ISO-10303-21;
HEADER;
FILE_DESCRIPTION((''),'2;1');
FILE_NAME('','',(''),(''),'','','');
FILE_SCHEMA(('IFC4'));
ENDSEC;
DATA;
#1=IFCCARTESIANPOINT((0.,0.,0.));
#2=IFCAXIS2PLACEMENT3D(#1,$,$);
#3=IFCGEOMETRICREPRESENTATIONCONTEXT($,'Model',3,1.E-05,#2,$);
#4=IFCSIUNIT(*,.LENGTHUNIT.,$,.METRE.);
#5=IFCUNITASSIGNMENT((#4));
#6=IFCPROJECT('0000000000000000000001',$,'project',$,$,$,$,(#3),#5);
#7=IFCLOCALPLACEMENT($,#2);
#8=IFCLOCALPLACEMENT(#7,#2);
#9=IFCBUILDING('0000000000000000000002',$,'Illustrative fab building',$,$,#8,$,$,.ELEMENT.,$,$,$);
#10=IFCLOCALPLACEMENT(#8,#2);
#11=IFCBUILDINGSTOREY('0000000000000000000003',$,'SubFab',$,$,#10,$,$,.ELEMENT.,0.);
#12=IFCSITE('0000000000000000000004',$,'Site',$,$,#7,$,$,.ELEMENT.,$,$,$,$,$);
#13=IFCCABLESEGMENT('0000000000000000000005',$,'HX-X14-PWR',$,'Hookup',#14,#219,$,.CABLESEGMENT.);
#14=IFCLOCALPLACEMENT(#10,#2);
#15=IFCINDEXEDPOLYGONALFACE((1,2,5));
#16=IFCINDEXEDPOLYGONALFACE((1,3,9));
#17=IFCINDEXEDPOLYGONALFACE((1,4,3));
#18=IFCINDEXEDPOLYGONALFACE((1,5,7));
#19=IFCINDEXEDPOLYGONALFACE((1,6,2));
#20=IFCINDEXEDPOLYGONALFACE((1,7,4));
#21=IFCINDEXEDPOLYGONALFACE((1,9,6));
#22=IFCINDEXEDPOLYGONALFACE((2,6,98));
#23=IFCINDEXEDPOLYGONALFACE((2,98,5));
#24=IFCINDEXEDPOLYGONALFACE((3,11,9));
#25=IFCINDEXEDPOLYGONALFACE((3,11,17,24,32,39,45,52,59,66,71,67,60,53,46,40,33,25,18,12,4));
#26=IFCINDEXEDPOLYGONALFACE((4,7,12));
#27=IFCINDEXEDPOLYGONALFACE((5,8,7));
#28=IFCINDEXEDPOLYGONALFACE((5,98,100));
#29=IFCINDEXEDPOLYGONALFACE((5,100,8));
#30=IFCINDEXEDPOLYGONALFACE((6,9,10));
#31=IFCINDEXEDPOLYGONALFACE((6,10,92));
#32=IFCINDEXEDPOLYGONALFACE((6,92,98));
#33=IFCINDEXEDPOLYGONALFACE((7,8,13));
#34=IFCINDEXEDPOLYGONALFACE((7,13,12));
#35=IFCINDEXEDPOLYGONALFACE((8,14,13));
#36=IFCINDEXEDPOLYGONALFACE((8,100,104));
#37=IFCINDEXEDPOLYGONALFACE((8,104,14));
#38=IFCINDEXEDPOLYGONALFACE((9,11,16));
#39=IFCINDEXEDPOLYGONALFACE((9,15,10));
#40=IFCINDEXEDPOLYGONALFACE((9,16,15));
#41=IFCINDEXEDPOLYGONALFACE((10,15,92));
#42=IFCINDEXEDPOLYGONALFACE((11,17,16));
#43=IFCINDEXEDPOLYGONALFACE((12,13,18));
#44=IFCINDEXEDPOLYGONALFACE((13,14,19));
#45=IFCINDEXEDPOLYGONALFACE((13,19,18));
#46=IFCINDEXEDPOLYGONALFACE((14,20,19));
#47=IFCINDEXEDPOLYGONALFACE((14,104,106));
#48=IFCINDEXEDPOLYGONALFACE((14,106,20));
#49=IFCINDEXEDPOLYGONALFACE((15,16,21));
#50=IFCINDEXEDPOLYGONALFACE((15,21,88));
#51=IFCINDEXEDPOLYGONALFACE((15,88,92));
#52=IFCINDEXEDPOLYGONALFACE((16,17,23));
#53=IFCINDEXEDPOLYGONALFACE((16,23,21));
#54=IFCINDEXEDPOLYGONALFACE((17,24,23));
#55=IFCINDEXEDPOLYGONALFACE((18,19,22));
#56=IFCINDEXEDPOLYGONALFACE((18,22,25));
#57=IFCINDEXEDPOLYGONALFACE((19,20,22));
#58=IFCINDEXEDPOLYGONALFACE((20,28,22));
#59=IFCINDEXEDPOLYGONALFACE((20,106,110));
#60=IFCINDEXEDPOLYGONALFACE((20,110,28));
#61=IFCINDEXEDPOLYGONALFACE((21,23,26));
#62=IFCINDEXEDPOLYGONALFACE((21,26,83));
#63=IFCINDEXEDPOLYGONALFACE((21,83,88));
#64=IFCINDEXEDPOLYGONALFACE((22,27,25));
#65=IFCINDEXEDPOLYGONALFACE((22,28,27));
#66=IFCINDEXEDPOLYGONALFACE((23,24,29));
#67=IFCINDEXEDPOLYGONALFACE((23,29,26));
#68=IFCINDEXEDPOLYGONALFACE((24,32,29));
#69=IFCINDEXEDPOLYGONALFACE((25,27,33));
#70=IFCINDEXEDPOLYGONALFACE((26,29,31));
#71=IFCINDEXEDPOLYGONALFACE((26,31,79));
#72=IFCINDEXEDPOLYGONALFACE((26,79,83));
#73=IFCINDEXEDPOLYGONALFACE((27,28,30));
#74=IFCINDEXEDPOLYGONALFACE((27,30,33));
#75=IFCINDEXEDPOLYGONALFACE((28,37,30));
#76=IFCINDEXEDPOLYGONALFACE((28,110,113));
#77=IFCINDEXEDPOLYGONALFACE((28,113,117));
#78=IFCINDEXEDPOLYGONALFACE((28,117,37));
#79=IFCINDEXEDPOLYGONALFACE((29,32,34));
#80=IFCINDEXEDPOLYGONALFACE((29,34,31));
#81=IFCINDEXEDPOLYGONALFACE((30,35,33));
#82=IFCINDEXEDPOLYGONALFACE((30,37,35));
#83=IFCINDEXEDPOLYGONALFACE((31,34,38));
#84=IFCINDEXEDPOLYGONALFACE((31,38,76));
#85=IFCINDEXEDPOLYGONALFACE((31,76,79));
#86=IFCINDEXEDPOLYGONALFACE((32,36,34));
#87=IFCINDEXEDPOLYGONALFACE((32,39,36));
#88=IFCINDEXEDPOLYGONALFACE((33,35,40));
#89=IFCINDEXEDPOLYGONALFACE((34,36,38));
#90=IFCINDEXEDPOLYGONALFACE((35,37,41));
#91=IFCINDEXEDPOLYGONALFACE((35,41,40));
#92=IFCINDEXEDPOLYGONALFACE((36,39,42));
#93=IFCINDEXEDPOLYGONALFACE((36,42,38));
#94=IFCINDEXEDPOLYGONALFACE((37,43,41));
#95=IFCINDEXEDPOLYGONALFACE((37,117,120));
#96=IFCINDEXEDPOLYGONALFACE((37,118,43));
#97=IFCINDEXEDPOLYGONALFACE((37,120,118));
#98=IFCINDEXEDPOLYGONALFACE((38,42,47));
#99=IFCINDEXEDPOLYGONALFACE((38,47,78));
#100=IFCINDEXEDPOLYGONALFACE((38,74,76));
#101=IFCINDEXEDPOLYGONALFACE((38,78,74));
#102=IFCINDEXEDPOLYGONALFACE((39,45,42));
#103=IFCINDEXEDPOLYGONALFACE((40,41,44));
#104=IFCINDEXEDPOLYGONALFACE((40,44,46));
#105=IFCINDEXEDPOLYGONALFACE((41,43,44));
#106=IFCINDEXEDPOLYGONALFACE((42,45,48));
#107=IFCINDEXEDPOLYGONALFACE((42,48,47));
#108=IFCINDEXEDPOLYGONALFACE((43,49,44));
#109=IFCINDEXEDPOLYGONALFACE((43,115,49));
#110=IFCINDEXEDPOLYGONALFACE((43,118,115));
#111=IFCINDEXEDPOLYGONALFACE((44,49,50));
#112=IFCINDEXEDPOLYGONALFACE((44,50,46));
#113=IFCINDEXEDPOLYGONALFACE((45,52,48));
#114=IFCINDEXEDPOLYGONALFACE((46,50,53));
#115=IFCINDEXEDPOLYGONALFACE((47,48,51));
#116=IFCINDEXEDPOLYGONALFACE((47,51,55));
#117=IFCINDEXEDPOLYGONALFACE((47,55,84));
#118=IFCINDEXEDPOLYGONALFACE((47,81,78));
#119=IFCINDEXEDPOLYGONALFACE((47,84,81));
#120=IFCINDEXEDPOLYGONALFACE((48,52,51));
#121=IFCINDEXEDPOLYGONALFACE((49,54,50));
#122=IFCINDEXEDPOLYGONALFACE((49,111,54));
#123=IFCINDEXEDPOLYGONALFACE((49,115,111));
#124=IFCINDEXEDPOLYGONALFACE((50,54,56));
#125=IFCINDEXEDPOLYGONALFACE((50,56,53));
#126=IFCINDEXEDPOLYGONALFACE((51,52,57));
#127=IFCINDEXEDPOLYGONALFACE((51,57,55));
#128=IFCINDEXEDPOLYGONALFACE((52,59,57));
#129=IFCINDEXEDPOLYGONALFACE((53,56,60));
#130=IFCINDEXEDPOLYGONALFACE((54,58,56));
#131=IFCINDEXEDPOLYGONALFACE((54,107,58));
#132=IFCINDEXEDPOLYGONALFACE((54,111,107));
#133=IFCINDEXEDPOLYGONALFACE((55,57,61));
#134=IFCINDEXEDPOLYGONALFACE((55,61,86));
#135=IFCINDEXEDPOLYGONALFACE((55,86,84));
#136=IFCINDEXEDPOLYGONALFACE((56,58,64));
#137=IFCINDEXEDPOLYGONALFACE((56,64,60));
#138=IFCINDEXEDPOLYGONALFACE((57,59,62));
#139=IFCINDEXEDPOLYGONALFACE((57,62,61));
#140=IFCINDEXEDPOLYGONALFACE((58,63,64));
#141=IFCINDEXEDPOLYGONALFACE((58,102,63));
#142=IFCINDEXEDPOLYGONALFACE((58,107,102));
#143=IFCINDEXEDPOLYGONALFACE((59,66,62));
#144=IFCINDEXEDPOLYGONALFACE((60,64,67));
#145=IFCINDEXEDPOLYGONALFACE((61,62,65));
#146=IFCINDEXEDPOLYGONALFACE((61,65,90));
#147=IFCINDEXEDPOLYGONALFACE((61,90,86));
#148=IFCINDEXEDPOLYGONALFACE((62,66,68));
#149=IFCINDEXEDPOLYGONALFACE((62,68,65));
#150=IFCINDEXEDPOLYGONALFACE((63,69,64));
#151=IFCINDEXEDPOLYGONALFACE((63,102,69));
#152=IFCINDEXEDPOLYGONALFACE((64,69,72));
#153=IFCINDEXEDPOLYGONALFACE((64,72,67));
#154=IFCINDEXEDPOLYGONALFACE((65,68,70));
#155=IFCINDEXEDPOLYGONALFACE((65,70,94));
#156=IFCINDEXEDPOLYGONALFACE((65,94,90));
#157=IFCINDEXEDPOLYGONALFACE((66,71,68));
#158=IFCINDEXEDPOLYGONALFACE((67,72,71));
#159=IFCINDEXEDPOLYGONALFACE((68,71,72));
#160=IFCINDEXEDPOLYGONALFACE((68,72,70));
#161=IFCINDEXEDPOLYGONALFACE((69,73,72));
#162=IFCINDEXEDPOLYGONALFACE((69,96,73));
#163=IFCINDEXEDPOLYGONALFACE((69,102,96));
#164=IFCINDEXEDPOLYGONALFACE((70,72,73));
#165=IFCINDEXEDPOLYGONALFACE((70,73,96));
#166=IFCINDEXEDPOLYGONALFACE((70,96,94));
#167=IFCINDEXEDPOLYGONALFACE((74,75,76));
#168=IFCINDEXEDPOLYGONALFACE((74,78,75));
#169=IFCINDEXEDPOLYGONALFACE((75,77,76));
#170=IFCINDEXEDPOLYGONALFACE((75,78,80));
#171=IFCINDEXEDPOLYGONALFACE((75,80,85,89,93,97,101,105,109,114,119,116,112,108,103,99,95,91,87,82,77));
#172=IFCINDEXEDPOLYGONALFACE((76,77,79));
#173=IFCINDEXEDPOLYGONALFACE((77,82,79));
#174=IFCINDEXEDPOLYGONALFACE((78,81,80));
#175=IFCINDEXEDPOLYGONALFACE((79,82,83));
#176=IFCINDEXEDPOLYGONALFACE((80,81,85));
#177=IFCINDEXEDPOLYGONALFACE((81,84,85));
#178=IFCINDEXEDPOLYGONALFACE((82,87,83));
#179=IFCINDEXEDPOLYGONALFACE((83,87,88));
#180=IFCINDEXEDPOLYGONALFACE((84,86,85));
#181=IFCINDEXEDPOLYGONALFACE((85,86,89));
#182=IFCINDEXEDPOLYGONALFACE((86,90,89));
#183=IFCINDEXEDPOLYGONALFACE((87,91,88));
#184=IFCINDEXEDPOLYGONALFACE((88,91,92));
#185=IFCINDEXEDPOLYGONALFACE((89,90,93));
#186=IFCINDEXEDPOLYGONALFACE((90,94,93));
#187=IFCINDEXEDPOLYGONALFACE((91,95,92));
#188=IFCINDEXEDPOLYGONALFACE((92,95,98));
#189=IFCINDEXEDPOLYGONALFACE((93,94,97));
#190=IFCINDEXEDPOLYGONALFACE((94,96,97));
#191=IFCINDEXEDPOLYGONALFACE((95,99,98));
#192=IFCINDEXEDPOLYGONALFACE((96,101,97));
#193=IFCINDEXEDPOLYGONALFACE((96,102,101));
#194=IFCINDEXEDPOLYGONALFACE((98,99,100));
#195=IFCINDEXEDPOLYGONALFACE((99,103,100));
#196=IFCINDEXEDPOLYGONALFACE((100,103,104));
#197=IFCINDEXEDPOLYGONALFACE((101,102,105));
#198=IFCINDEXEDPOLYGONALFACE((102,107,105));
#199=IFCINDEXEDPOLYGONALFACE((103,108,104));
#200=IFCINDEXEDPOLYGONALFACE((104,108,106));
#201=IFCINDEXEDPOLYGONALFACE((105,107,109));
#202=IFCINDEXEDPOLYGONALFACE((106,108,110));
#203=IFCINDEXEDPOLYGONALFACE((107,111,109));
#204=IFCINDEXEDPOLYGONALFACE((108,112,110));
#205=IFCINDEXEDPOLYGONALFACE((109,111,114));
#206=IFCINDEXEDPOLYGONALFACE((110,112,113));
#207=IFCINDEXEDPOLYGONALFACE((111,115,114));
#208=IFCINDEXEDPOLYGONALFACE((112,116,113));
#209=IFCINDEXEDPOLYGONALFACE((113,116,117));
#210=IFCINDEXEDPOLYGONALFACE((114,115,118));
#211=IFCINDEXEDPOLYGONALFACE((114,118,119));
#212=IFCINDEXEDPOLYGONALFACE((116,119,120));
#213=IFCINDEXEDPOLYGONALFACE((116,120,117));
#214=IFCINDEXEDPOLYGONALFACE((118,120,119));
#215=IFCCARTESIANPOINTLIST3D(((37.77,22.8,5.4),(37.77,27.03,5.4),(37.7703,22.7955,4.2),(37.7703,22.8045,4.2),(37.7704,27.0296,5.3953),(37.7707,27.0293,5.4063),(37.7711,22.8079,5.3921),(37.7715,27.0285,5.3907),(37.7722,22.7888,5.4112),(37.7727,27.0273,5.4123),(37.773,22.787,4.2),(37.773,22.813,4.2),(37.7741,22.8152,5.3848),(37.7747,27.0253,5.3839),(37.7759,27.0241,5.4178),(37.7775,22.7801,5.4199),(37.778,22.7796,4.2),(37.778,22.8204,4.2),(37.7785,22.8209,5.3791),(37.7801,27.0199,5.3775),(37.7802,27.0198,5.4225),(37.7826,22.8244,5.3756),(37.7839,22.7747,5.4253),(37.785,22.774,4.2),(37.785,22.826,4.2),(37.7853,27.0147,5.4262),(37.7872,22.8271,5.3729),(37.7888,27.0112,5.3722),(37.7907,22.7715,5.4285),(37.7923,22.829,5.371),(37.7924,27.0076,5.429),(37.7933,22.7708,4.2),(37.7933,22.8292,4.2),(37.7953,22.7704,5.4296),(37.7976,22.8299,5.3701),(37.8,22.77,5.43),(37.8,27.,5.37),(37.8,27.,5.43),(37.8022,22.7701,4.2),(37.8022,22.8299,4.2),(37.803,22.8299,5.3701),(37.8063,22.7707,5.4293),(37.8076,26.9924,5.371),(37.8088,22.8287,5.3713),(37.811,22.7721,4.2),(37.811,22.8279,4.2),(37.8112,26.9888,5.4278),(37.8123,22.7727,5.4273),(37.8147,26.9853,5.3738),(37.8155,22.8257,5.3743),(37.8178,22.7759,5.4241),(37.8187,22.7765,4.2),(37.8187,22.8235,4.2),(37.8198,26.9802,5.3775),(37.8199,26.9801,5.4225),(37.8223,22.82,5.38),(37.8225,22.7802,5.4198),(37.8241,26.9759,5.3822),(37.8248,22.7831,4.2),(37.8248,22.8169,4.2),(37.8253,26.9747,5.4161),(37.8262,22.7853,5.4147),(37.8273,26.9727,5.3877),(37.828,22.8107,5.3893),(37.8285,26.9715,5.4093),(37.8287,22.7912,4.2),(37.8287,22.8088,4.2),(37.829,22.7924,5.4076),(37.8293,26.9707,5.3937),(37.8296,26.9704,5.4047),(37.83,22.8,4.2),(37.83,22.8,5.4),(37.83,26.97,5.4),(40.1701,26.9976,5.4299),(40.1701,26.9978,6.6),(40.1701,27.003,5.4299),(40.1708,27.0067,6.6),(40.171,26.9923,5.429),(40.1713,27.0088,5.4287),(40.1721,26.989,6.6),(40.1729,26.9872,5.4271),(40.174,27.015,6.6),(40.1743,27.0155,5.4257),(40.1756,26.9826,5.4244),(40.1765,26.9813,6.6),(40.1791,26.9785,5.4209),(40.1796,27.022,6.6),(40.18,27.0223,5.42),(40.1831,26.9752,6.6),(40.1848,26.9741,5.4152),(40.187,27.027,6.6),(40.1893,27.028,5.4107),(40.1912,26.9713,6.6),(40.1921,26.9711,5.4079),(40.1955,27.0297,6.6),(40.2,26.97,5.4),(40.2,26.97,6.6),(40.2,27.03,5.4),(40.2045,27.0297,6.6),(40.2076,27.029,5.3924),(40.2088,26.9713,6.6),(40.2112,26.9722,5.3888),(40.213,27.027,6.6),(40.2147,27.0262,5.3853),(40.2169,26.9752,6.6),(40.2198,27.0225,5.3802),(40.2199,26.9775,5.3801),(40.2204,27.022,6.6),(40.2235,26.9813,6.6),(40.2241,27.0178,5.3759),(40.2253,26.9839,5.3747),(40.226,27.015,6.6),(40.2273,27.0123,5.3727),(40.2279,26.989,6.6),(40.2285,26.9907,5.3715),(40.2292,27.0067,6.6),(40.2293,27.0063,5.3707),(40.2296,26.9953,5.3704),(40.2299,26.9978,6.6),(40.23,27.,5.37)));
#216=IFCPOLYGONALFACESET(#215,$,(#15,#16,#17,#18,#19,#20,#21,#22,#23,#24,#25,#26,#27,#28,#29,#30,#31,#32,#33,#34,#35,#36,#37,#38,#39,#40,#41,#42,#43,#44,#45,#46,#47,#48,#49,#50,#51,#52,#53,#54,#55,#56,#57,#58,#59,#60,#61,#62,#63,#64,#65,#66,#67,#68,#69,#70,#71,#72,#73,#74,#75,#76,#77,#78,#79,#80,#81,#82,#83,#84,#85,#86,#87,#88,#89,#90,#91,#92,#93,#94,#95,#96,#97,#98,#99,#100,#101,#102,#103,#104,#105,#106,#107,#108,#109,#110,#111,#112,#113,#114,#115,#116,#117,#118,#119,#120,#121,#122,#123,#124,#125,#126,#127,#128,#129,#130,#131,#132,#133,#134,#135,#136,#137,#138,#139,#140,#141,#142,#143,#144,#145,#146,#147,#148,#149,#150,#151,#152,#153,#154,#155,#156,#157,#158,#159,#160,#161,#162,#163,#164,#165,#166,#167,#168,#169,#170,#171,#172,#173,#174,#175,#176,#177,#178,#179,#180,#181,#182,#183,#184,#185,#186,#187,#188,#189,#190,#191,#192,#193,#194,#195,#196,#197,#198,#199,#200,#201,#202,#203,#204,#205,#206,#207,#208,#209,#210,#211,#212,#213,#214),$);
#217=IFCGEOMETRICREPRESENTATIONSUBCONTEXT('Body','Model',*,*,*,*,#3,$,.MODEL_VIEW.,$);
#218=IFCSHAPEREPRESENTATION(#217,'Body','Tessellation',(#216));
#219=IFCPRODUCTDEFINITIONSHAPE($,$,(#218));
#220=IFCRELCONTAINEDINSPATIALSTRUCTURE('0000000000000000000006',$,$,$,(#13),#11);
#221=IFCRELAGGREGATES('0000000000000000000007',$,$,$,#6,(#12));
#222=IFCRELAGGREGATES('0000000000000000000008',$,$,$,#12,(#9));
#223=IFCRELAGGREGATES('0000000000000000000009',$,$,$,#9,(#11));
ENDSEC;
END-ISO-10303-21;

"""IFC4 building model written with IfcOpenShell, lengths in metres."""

from ifc_helpers import new_model, entity, si_unit, origin, place, context, subcontext, project, spatial, element, save


model = new_model("IFC4")

# Units and contexts
model_context = context("Model", 3, precision=1e-05, world=origin())
body_context = subcontext(model_context, "Body", "Model", "MODEL_VIEW")
ifc_project = project(units=[si_unit("LENGTHUNIT", "METRE")], contexts=[model_context])

# Site, building, storey
site_placement = place(None, origin())
site = spatial("IfcSite", under=ifc_project, at=site_placement, Name="Site", CompositionType="ELEMENT")
building_placement = place(site_placement, origin())
building = spatial("IfcBuilding", under=site, at=building_placement, Name="Illustrative fab building", CompositionType="ELEMENT")
storey_placement = place(building_placement, origin())
storey = spatial("IfcBuildingStorey", under=building, at=storey_placement, Name="SubFab", CompositionType="ELEMENT", Elevation=0.0)

# Cable segment
cable_segment_1_placement = place(storey_placement, origin())
element("IfcCableSegment", 1, at=cable_segment_1_placement, inside=storey, Name="HX-X14-PWR", ObjectType="Hookup", PredefinedType="CABLESEGMENT", context=body_context, shape_type="AdvancedSweptSolid", body=[
    entity("IfcSweptDiskSolid", entity("IfcPolyline", [entity("IfcCartesianPoint", [37.8, 22.8, 4.2]), entity("IfcCartesianPoint", [37.8, 22.8, 5.4]), entity("IfcCartesianPoint", [37.8, 27.0, 5.4]), entity("IfcCartesianPoint", [40.2, 27.0, 5.4]), entity("IfcCartesianPoint", [40.2, 27.0, 6.6])]), 0.03),
])

save(model, "model.ifc")
